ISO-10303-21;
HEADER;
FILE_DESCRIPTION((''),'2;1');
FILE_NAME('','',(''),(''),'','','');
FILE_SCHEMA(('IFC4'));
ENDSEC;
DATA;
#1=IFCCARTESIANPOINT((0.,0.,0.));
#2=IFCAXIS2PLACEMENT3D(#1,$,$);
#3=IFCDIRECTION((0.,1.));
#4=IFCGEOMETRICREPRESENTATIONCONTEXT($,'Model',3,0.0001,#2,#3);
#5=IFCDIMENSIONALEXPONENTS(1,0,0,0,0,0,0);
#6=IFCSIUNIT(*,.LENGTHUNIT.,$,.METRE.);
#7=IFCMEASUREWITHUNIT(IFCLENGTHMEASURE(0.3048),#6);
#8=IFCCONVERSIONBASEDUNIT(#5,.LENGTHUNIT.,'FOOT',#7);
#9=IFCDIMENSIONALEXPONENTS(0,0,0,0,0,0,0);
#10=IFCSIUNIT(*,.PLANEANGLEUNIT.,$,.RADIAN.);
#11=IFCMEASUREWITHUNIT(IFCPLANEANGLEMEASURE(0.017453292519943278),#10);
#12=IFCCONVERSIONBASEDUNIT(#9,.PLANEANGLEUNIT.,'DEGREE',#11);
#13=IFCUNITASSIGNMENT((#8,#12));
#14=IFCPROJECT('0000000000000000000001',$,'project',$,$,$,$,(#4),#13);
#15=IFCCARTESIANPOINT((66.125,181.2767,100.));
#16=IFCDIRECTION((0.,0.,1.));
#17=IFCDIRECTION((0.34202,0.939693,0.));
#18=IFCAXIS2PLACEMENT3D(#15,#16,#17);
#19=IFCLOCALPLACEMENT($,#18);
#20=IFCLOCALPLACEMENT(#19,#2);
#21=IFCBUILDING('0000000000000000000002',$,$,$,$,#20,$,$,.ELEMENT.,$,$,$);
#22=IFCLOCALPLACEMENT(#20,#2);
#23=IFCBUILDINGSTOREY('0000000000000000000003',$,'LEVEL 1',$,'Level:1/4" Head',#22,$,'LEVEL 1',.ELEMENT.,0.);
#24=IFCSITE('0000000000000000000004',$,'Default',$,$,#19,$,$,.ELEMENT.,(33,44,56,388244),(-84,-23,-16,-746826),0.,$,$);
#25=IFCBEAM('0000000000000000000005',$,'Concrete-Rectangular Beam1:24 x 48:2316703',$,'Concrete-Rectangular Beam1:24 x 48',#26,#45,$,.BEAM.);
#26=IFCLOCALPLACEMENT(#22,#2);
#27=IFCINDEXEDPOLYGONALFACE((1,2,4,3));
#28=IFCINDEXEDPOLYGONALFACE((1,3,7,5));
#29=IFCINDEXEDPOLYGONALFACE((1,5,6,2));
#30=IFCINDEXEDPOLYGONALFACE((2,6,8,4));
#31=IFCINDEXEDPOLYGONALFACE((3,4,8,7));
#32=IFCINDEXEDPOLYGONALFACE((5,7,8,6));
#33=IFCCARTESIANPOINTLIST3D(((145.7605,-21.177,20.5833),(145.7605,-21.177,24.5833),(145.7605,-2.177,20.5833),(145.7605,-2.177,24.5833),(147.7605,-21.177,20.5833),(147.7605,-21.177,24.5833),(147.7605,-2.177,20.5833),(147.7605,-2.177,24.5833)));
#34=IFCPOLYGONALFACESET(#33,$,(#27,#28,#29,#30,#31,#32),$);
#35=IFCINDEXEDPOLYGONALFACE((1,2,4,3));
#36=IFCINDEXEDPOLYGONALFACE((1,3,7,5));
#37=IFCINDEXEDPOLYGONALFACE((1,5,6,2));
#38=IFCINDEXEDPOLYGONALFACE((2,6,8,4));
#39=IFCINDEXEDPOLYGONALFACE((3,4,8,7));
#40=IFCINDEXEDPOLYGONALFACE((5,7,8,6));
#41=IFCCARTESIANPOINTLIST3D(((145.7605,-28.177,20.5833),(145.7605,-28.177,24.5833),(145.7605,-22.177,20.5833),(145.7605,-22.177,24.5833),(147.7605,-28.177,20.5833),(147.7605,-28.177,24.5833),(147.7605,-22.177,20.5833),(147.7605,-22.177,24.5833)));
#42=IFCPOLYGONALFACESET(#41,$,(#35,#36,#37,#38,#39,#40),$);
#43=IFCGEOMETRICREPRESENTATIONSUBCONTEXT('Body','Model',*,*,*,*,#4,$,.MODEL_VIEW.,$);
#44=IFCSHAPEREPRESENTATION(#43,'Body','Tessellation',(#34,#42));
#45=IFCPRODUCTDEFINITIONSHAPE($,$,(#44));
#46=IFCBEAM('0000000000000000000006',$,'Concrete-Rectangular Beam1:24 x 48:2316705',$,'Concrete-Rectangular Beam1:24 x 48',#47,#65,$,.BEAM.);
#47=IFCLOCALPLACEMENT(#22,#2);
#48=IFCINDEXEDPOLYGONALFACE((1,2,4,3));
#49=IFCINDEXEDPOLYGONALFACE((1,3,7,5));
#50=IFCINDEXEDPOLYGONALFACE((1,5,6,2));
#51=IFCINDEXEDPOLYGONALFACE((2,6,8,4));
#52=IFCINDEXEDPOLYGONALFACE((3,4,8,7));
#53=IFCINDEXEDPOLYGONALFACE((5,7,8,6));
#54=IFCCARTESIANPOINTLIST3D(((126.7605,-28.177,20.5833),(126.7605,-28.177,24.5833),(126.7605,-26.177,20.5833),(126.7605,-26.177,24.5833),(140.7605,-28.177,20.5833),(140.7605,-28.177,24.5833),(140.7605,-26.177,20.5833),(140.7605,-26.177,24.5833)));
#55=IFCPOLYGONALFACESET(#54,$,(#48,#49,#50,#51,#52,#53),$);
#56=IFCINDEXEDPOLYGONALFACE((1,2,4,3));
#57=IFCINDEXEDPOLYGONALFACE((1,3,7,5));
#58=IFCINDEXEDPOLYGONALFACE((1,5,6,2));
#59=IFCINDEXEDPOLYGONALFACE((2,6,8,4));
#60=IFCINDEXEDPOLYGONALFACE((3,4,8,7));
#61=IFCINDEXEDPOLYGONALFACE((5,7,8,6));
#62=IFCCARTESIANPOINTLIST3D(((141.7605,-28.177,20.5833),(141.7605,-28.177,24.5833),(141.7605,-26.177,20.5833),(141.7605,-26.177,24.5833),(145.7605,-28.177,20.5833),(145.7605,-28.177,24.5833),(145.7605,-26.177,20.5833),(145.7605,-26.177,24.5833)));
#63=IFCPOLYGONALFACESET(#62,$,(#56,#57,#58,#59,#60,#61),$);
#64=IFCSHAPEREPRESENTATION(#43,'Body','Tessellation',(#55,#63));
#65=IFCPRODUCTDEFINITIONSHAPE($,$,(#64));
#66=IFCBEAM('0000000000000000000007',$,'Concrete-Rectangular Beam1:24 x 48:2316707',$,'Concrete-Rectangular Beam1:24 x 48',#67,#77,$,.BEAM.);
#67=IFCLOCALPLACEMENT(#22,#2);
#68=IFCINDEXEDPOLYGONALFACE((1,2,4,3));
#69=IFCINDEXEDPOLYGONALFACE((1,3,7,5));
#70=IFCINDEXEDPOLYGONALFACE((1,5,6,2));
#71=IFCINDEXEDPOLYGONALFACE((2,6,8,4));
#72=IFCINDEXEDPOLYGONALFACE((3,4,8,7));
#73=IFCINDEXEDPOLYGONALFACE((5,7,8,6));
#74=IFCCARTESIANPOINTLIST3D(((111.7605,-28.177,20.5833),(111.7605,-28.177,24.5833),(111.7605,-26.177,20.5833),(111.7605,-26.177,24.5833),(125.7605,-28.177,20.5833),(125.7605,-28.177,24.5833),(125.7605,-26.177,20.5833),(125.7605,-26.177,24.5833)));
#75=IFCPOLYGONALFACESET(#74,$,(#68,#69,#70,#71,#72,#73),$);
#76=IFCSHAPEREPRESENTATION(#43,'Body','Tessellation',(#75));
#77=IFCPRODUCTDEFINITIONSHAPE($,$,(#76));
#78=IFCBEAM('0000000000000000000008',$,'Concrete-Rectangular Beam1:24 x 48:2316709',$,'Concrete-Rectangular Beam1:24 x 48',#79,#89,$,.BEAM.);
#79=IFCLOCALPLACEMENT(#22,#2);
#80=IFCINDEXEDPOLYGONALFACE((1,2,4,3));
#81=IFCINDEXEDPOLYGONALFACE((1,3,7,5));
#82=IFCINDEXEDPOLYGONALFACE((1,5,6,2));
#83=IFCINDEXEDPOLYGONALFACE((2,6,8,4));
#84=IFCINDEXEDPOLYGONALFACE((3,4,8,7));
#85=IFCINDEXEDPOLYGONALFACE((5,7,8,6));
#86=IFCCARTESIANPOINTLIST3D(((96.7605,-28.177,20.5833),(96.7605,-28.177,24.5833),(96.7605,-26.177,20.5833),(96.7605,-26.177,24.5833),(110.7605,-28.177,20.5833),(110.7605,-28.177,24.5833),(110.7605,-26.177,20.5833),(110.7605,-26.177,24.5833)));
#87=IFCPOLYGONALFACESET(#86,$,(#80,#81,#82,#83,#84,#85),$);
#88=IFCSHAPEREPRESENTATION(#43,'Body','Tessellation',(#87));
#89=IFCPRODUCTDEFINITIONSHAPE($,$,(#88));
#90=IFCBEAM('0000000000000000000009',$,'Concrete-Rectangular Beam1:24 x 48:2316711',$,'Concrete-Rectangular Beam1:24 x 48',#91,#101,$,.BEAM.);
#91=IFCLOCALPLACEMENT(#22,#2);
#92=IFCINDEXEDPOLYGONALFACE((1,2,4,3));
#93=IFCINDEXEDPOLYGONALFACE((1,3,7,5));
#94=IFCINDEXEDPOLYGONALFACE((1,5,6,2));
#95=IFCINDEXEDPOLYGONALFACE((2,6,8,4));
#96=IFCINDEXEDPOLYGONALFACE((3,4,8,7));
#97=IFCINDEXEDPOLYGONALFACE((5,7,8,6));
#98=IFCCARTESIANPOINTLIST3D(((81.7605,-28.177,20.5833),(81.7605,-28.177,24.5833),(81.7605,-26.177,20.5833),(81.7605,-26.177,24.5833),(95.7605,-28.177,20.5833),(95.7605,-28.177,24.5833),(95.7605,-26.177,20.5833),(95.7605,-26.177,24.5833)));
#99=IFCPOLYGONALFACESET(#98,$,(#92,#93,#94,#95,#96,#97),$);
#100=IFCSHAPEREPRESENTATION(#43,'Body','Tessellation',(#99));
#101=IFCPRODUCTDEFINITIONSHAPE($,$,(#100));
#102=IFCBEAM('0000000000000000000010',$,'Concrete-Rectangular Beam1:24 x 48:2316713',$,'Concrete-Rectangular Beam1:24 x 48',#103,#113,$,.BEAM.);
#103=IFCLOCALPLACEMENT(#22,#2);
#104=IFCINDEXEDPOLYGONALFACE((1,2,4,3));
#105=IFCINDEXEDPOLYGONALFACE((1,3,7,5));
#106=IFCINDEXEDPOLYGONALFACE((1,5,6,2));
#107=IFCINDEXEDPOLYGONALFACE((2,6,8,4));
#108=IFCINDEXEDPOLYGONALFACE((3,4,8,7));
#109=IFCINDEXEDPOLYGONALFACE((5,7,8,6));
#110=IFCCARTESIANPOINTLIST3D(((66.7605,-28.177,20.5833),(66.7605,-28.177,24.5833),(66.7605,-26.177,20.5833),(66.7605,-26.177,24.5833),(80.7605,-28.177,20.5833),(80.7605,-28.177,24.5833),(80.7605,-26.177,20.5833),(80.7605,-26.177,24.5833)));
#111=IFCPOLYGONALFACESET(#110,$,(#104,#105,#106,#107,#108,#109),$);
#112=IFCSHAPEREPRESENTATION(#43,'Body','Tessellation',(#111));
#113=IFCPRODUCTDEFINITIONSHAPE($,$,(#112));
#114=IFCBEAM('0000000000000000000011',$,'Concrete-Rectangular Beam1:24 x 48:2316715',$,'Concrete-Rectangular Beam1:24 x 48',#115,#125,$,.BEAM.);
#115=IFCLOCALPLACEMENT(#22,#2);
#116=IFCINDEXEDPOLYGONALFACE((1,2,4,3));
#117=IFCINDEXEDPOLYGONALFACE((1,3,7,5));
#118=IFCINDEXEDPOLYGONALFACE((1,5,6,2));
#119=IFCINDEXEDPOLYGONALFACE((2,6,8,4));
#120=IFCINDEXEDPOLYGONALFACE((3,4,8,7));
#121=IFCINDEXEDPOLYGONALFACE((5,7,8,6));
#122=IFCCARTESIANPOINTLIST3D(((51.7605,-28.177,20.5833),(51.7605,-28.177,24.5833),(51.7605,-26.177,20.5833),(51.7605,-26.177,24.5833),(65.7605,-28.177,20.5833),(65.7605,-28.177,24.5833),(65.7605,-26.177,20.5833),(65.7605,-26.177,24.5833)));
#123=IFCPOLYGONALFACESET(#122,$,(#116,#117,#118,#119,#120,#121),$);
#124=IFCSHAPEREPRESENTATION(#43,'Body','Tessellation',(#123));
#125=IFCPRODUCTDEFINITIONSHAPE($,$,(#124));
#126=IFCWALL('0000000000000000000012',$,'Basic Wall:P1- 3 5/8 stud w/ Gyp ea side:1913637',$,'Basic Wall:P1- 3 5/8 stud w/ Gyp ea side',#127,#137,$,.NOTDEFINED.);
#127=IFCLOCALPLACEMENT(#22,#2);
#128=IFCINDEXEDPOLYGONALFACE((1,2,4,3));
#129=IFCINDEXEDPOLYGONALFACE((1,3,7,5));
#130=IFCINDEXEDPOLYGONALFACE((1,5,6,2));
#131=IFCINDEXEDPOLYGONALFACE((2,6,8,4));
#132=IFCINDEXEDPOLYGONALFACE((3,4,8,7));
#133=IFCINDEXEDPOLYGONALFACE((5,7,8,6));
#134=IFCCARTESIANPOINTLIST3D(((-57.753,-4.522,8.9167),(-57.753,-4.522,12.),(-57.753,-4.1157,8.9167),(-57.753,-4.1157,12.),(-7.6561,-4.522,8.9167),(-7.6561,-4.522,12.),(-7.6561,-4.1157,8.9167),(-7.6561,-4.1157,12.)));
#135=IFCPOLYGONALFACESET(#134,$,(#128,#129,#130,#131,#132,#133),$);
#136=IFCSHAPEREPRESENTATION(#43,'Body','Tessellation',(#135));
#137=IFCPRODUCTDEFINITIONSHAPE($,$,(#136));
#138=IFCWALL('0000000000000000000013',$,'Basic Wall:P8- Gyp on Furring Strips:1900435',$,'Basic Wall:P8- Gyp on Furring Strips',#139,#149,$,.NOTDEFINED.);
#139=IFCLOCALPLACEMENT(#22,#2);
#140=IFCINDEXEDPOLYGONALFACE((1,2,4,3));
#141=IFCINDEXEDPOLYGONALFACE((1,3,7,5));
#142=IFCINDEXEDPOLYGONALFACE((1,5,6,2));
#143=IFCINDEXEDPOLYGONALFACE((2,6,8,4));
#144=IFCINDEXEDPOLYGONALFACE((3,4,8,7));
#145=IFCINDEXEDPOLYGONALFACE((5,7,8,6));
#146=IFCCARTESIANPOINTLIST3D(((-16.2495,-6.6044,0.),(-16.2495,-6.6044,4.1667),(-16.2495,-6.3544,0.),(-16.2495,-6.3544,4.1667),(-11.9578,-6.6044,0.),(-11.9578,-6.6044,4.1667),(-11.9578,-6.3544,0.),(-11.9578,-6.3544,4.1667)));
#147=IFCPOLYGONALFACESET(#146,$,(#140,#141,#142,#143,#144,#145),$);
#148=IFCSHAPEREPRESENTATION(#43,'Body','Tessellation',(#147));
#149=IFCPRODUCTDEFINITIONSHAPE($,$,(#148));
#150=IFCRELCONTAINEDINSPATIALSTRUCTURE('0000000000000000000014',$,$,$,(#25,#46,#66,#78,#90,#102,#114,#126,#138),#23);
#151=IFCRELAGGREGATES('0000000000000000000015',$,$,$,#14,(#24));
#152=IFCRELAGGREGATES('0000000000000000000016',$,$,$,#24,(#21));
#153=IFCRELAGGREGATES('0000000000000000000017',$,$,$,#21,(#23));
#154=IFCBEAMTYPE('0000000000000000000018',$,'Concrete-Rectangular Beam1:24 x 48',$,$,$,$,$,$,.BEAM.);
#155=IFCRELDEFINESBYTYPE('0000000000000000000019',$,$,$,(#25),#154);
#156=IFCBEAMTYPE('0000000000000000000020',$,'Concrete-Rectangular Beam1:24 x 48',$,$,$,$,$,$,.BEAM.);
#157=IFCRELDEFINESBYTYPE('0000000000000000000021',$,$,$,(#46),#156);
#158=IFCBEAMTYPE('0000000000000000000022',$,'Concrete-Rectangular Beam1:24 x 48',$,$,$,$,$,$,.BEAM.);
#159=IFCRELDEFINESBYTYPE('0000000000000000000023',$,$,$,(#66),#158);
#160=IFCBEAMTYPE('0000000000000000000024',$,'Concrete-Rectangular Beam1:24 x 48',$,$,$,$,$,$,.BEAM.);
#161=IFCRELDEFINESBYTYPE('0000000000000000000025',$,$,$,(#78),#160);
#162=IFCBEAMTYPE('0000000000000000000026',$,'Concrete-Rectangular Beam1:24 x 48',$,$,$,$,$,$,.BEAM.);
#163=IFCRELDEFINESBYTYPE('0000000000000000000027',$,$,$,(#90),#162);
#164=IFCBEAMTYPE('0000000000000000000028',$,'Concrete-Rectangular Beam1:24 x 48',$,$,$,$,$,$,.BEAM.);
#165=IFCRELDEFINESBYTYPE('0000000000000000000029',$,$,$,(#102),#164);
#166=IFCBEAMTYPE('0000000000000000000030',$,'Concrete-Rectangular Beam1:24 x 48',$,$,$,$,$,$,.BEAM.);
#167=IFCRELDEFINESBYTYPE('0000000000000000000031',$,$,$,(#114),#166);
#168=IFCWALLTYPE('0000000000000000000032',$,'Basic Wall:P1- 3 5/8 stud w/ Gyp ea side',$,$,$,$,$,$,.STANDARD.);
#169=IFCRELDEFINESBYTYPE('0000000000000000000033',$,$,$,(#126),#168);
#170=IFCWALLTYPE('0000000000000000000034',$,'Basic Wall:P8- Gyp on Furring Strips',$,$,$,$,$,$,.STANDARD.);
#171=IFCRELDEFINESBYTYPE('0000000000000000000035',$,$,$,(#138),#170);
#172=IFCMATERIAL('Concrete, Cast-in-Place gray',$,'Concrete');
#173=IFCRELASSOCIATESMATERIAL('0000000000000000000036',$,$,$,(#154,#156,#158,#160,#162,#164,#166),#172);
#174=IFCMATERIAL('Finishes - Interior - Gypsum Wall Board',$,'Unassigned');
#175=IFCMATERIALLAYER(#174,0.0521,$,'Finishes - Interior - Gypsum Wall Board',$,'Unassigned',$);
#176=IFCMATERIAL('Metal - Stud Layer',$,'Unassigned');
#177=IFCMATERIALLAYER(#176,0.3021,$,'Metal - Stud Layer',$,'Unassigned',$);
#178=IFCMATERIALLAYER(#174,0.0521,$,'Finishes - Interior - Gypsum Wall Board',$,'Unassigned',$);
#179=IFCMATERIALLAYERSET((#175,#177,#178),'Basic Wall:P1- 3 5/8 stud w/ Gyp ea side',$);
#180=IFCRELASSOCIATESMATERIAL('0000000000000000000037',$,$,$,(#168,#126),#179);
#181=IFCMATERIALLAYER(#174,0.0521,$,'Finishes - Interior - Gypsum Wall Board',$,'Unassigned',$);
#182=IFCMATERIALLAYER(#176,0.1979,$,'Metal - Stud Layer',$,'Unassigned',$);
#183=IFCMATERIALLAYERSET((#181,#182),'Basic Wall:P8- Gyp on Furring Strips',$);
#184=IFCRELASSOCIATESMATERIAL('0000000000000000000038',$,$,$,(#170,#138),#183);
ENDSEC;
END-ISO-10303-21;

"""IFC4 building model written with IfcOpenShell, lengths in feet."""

from ifc_helpers import new_model, entity, si_unit, converted_unit, direction, frame, frame_2d, origin, origin_2d_with_axis, place, context, subcontext, project, spatial, rectangle, extrude, source, transform, mapped, material, layer, layer_set, layer_usage, material_profile, profile_set, type_object, type_shapes, element, save


model = new_model("IFC4")

# Units and contexts
model_context = context("Model", 3, precision=0.0001, world=origin(), true_north=direction((0.0, 1.0)))
body_context = subcontext(model_context, "Body", "Model", "MODEL_VIEW")
ifc_project = project(units=[converted_unit("LENGTHUNIT", "FOOT", entity("IfcLengthMeasure", 0.3048), si_unit("LENGTHUNIT", "METRE"), dimensions=[1, 0, 0, 0, 0, 0, 0]), converted_unit("PLANEANGLEUNIT", "DEGREE", entity("IfcPlaneAngleMeasure", 0.017453292519943278), si_unit("PLANEANGLEUNIT", "RADIAN"), dimensions=[0, 0, 0, 0, 0, 0, 0])], contexts=[model_context])

# Site, building, storey
site_placement = place(None, frame((66.125, 181.2767, 100.0), z_axis=(0.0, 0.0, 1.0), x_axis=(0.34202, 0.939693, 0.0)))
site = spatial("IfcSite", under=ifc_project, at=site_placement, Name="Default", CompositionType="ELEMENT", RefLatitude=(33, 44, 56, 388244), RefLongitude=(-84, -23, -16, -746826), RefElevation=0.0)
building_placement = place(site_placement, origin())
building = spatial("IfcBuilding", under=site, at=building_placement, CompositionType="ELEMENT")
storey_placement = place(building_placement, origin())
storey = spatial("IfcBuildingStorey", under=building, at=storey_placement, Name="LEVEL 1", ObjectType="Level:1/4\" Head", LongName="LEVEL 1", CompositionType="ELEMENT", Elevation=0.0)

# Beams
ifc_material_1 = material(Name="Concrete, Cast-in-Place gray", Category="Concrete")
ifc_material_profile = material_profile(ifc_material_1, rectangle(XDim=4.0, YDim=2.0, at=frame_2d((0.0, 0.0), x_axis=(1.0, 0.0))), Name="24 x 48")
ifc_profile_set = profile_set([ifc_material_profile], Name="24 x 48")
beam_type_1 = type_object("IfcBeamType", Name="Concrete-Rectangular Beam1:24 x 48", PredefinedType="BEAM", material=ifc_profile_set)
shared_shape_1 = source(origin(), body_context, "Body", "SweptSolid", [
    extrude(rectangle(XDim=4.0, YDim=2.0, at=frame_2d((0.0, 0.0), x_axis=(0.0, 1.0))), frame((146.7605, -2.177, 22.5833), z_axis=(0.0, -1.0, 0.0), x_axis=(-1.0, 0.0, 0.0)), (0.0, 0.0, 1.0), 19.0),
    extrude(rectangle(XDim=4.0, YDim=2.0, at=frame_2d((0.0, 0.0), x_axis=(0.0, 1.0))), frame((146.7605, -22.177, 22.5833), z_axis=(0.0, -1.0, 0.0), x_axis=(-1.0, 0.0, 0.0)), (0.0, 0.0, 1.0), 6.0),
])
type_shapes(beam_type_1, [shared_shape_1])
beam_1_placement = place(storey_placement, origin())
element("IfcBeam", 1, at=beam_1_placement, inside=storey, type_object=beam_type_1, Name="Concrete-Rectangular Beam1:24 x 48:2316703", ObjectType="Concrete-Rectangular Beam1:24 x 48", PredefinedType="BEAM", context=body_context, shape_type="MappedRepresentation", body=[
    mapped(shared_shape_1, transform((0.0, 0.0, 0.0), scale=1.0)),
])
beam_type_2 = type_object("IfcBeamType", Name="Concrete-Rectangular Beam1:24 x 48", PredefinedType="BEAM", material=ifc_profile_set)
shared_shape_2 = source(origin(), body_context, "Body", "SweptSolid", [
    extrude(rectangle(XDim=4.0, YDim=2.0, at=frame_2d((0.0, 0.0), x_axis=(1.0, 0.0))), frame((140.7605, -27.177, 22.5833), z_axis=(-1.0, 0.0, 0.0), x_axis=(0.0, 0.0, -1.0)), (0.0, 0.0, 1.0), 14.0),
    extrude(rectangle(XDim=4.0, YDim=2.0, at=frame_2d((0.0, 0.0), x_axis=(1.0, 0.0))), frame((145.7605, -27.177, 22.5833), z_axis=(-1.0, 0.0, 0.0), x_axis=(0.0, 0.0, -1.0)), (0.0, 0.0, 1.0), 4.0),
])
type_shapes(beam_type_2, [shared_shape_2])
beam_2_placement = place(storey_placement, origin())
element("IfcBeam", 2, at=beam_2_placement, inside=storey, type_object=beam_type_2, Name="Concrete-Rectangular Beam1:24 x 48:2316705", ObjectType="Concrete-Rectangular Beam1:24 x 48", PredefinedType="BEAM", context=body_context, shape_type="MappedRepresentation", body=[
    mapped(shared_shape_2, transform((0.0, 0.0, 0.0), scale=1.0)),
])
beam_type_3 = type_object("IfcBeamType", Name="Concrete-Rectangular Beam1:24 x 48", PredefinedType="BEAM", material=ifc_profile_set)
shared_shape_3 = source(origin(), body_context, "Body", "SweptSolid", [
    extrude(rectangle(XDim=4.0, YDim=2.0, at=origin_2d_with_axis()), frame((125.7605, -27.177, 22.5833), z_axis=(-1.0, 0.0, 0.0), x_axis=(0.0, 0.0, -1.0)), (0.0, 0.0, 1.0), 14.0),
])
type_shapes(beam_type_3, [shared_shape_3])
beam_3_placement = place(storey_placement, origin())
element("IfcBeam", 3, at=beam_3_placement, inside=storey, type_object=beam_type_3, Name="Concrete-Rectangular Beam1:24 x 48:2316707", ObjectType="Concrete-Rectangular Beam1:24 x 48", PredefinedType="BEAM", context=body_context, shape_type="MappedRepresentation", body=[
    mapped(shared_shape_3, transform((0.0, 0.0, 0.0), scale=1.0)),
])
beam_type_4 = type_object("IfcBeamType", Name="Concrete-Rectangular Beam1:24 x 48", PredefinedType="BEAM", material=ifc_profile_set)
shared_shape_4 = source(origin(), body_context, "Body", "SweptSolid", [
    extrude(rectangle(XDim=4.0, YDim=2.0, at=frame_2d((0.0, 0.0), x_axis=(1.0, 0.0))), frame((110.7605, -27.177, 22.5833), z_axis=(-1.0, 0.0, 0.0), x_axis=(0.0, 0.0, -1.0)), (0.0, 0.0, 1.0), 14.0),
])
type_shapes(beam_type_4, [shared_shape_4])
beam_4_placement = place(storey_placement, origin())
element("IfcBeam", 4, at=beam_4_placement, inside=storey, type_object=beam_type_4, Name="Concrete-Rectangular Beam1:24 x 48:2316709", ObjectType="Concrete-Rectangular Beam1:24 x 48", PredefinedType="BEAM", context=body_context, shape_type="MappedRepresentation", body=[
    mapped(shared_shape_4, transform((0.0, 0.0, 0.0), scale=1.0)),
])
beam_type_5 = type_object("IfcBeamType", Name="Concrete-Rectangular Beam1:24 x 48", PredefinedType="BEAM", material=ifc_profile_set)
shared_shape_5 = source(origin(), body_context, "Body", "SweptSolid", [
    extrude(rectangle(XDim=4.0, YDim=2.0, at=origin_2d_with_axis()), frame((95.7605, -27.177, 22.5833), z_axis=(-1.0, 0.0, 0.0), x_axis=(0.0, 0.0, -1.0)), (0.0, 0.0, 1.0), 14.0),
])
type_shapes(beam_type_5, [shared_shape_5])
beam_5_placement = place(storey_placement, origin())
element("IfcBeam", 5, at=beam_5_placement, inside=storey, type_object=beam_type_5, Name="Concrete-Rectangular Beam1:24 x 48:2316711", ObjectType="Concrete-Rectangular Beam1:24 x 48", PredefinedType="BEAM", context=body_context, shape_type="MappedRepresentation", body=[
    mapped(shared_shape_5, transform((0.0, 0.0, 0.0), scale=1.0)),
])
beam_type_6 = type_object("IfcBeamType", Name="Concrete-Rectangular Beam1:24 x 48", PredefinedType="BEAM", material=ifc_profile_set)
shared_shape_6 = source(origin(), body_context, "Body", "SweptSolid", [
    extrude(rectangle(XDim=4.0, YDim=2.0, at=frame_2d((0.0, 0.0), x_axis=(1.0, 0.0))), frame((80.7605, -27.177, 22.5833), z_axis=(-1.0, 0.0, 0.0), x_axis=(0.0, 0.0, -1.0)), (0.0, 0.0, 1.0), 14.0),
])
type_shapes(beam_type_6, [shared_shape_6])
beam_6_placement = place(storey_placement, origin())
element("IfcBeam", 6, at=beam_6_placement, inside=storey, type_object=beam_type_6, Name="Concrete-Rectangular Beam1:24 x 48:2316713", ObjectType="Concrete-Rectangular Beam1:24 x 48", PredefinedType="BEAM", context=body_context, shape_type="MappedRepresentation", body=[
    mapped(shared_shape_6, transform((0.0, 0.0, 0.0), scale=1.0)),
])
beam_type_7 = type_object("IfcBeamType", Name="Concrete-Rectangular Beam1:24 x 48", PredefinedType="BEAM", material=ifc_profile_set)
shared_shape_7 = source(origin(), body_context, "Body", "SweptSolid", [
    extrude(rectangle(XDim=4.0, YDim=2.0, at=frame_2d((0.0, 0.0), x_axis=(1.0, 0.0))), frame((65.7605, -27.177, 22.5833), z_axis=(-1.0, 0.0, 0.0), x_axis=(0.0, 0.0, -1.0)), (0.0, 0.0, 1.0), 14.0),
])
type_shapes(beam_type_7, [shared_shape_7])
beam_7_placement = place(storey_placement, origin())
element("IfcBeam", 7, at=beam_7_placement, inside=storey, type_object=beam_type_7, Name="Concrete-Rectangular Beam1:24 x 48:2316715", ObjectType="Concrete-Rectangular Beam1:24 x 48", PredefinedType="BEAM", context=body_context, shape_type="MappedRepresentation", body=[
    mapped(shared_shape_7, transform((0.0, 0.0, 0.0), scale=1.0)),
])

# Walls
ifc_material_2 = material(Name="Finishes - Interior - Gypsum Wall Board", Category="Unassigned")
ifc_layer_1 = layer(ifc_material_2, 0.0521, Name="Finishes - Interior - Gypsum Wall Board", Category="Unassigned")
ifc_material_3 = material(Name="Metal - Stud Layer", Category="Unassigned")
ifc_layer_2 = layer(ifc_material_3, 0.3021, Name="Metal - Stud Layer", Category="Unassigned")
ifc_layer_3 = layer(ifc_material_2, 0.0521, Name="Finishes - Interior - Gypsum Wall Board", Category="Unassigned")
ifc_layer_set_1 = layer_set([ifc_layer_1, ifc_layer_2, ifc_layer_3], Name="Basic Wall:P1- 3 5/8 stud w/ Gyp ea side")
ifc_layer_usage_1 = layer_usage(ifc_layer_set_1, "AXIS2", "NEGATIVE", 0.2031)
wall_type_1 = type_object("IfcWallType", Name="Basic Wall:P1- 3 5/8 stud w/ Gyp ea side", PredefinedType="STANDARD", material=ifc_layer_set_1)
wall_1_placement = place(storey_placement, frame((-7.6561, -4.3188, 8.9167), z_axis=(0.0, 0.0, 1.0), x_axis=(-1.0, 0.0, 0.0)))
element("IfcWall", 8, at=wall_1_placement, inside=storey, type_object=wall_type_1, material=ifc_layer_usage_1, Name="Basic Wall:P1- 3 5/8 stud w/ Gyp ea side:1913637", ObjectType="Basic Wall:P1- 3 5/8 stud w/ Gyp ea side", PredefinedType="NOTDEFINED", context=body_context, shape_type="SweptSolid", body=[
    extrude(rectangle(XDim=50.0969, YDim=0.4062, at=frame_2d((25.0484, 0.0), x_axis=(-1.0, 0.0))), origin(), (0.0, 0.0, 1.0), 3.0833),
])
ifc_layer_4 = layer(ifc_material_2, 0.0521, Name="Finishes - Interior - Gypsum Wall Board", Category="Unassigned")
ifc_layer_5 = layer(ifc_material_3, 0.1979, Name="Metal - Stud Layer", Category="Unassigned")
ifc_layer_set_2 = layer_set([ifc_layer_4, ifc_layer_5], Name="Basic Wall:P8- Gyp on Furring Strips")
ifc_layer_usage_2 = layer_usage(ifc_layer_set_2, "AXIS2", "NEGATIVE", 0.125)
wall_type_2 = type_object("IfcWallType", Name="Basic Wall:P8- Gyp on Furring Strips", PredefinedType="STANDARD", material=ifc_layer_set_2)
wall_2_placement = place(storey_placement, frame((-11.9578, -6.4794, 0.0), z_axis=(0.0, 0.0, 1.0), x_axis=(-1.0, 0.0, 0.0)))
element("IfcWall", 9, at=wall_2_placement, inside=storey, type_object=wall_type_2, material=ifc_layer_usage_2, Name="Basic Wall:P8- Gyp on Furring Strips:1900435", ObjectType="Basic Wall:P8- Gyp on Furring Strips", PredefinedType="NOTDEFINED", context=body_context, shape_type="SweptSolid", body=[
    extrude(rectangle(XDim=4.2917, YDim=0.25, at=frame_2d((2.1458, 0.0), x_axis=(-1.0, 0.0))), origin(), (0.0, 0.0, 1.0), 4.1667),
])

save(model, "model.ifc")
